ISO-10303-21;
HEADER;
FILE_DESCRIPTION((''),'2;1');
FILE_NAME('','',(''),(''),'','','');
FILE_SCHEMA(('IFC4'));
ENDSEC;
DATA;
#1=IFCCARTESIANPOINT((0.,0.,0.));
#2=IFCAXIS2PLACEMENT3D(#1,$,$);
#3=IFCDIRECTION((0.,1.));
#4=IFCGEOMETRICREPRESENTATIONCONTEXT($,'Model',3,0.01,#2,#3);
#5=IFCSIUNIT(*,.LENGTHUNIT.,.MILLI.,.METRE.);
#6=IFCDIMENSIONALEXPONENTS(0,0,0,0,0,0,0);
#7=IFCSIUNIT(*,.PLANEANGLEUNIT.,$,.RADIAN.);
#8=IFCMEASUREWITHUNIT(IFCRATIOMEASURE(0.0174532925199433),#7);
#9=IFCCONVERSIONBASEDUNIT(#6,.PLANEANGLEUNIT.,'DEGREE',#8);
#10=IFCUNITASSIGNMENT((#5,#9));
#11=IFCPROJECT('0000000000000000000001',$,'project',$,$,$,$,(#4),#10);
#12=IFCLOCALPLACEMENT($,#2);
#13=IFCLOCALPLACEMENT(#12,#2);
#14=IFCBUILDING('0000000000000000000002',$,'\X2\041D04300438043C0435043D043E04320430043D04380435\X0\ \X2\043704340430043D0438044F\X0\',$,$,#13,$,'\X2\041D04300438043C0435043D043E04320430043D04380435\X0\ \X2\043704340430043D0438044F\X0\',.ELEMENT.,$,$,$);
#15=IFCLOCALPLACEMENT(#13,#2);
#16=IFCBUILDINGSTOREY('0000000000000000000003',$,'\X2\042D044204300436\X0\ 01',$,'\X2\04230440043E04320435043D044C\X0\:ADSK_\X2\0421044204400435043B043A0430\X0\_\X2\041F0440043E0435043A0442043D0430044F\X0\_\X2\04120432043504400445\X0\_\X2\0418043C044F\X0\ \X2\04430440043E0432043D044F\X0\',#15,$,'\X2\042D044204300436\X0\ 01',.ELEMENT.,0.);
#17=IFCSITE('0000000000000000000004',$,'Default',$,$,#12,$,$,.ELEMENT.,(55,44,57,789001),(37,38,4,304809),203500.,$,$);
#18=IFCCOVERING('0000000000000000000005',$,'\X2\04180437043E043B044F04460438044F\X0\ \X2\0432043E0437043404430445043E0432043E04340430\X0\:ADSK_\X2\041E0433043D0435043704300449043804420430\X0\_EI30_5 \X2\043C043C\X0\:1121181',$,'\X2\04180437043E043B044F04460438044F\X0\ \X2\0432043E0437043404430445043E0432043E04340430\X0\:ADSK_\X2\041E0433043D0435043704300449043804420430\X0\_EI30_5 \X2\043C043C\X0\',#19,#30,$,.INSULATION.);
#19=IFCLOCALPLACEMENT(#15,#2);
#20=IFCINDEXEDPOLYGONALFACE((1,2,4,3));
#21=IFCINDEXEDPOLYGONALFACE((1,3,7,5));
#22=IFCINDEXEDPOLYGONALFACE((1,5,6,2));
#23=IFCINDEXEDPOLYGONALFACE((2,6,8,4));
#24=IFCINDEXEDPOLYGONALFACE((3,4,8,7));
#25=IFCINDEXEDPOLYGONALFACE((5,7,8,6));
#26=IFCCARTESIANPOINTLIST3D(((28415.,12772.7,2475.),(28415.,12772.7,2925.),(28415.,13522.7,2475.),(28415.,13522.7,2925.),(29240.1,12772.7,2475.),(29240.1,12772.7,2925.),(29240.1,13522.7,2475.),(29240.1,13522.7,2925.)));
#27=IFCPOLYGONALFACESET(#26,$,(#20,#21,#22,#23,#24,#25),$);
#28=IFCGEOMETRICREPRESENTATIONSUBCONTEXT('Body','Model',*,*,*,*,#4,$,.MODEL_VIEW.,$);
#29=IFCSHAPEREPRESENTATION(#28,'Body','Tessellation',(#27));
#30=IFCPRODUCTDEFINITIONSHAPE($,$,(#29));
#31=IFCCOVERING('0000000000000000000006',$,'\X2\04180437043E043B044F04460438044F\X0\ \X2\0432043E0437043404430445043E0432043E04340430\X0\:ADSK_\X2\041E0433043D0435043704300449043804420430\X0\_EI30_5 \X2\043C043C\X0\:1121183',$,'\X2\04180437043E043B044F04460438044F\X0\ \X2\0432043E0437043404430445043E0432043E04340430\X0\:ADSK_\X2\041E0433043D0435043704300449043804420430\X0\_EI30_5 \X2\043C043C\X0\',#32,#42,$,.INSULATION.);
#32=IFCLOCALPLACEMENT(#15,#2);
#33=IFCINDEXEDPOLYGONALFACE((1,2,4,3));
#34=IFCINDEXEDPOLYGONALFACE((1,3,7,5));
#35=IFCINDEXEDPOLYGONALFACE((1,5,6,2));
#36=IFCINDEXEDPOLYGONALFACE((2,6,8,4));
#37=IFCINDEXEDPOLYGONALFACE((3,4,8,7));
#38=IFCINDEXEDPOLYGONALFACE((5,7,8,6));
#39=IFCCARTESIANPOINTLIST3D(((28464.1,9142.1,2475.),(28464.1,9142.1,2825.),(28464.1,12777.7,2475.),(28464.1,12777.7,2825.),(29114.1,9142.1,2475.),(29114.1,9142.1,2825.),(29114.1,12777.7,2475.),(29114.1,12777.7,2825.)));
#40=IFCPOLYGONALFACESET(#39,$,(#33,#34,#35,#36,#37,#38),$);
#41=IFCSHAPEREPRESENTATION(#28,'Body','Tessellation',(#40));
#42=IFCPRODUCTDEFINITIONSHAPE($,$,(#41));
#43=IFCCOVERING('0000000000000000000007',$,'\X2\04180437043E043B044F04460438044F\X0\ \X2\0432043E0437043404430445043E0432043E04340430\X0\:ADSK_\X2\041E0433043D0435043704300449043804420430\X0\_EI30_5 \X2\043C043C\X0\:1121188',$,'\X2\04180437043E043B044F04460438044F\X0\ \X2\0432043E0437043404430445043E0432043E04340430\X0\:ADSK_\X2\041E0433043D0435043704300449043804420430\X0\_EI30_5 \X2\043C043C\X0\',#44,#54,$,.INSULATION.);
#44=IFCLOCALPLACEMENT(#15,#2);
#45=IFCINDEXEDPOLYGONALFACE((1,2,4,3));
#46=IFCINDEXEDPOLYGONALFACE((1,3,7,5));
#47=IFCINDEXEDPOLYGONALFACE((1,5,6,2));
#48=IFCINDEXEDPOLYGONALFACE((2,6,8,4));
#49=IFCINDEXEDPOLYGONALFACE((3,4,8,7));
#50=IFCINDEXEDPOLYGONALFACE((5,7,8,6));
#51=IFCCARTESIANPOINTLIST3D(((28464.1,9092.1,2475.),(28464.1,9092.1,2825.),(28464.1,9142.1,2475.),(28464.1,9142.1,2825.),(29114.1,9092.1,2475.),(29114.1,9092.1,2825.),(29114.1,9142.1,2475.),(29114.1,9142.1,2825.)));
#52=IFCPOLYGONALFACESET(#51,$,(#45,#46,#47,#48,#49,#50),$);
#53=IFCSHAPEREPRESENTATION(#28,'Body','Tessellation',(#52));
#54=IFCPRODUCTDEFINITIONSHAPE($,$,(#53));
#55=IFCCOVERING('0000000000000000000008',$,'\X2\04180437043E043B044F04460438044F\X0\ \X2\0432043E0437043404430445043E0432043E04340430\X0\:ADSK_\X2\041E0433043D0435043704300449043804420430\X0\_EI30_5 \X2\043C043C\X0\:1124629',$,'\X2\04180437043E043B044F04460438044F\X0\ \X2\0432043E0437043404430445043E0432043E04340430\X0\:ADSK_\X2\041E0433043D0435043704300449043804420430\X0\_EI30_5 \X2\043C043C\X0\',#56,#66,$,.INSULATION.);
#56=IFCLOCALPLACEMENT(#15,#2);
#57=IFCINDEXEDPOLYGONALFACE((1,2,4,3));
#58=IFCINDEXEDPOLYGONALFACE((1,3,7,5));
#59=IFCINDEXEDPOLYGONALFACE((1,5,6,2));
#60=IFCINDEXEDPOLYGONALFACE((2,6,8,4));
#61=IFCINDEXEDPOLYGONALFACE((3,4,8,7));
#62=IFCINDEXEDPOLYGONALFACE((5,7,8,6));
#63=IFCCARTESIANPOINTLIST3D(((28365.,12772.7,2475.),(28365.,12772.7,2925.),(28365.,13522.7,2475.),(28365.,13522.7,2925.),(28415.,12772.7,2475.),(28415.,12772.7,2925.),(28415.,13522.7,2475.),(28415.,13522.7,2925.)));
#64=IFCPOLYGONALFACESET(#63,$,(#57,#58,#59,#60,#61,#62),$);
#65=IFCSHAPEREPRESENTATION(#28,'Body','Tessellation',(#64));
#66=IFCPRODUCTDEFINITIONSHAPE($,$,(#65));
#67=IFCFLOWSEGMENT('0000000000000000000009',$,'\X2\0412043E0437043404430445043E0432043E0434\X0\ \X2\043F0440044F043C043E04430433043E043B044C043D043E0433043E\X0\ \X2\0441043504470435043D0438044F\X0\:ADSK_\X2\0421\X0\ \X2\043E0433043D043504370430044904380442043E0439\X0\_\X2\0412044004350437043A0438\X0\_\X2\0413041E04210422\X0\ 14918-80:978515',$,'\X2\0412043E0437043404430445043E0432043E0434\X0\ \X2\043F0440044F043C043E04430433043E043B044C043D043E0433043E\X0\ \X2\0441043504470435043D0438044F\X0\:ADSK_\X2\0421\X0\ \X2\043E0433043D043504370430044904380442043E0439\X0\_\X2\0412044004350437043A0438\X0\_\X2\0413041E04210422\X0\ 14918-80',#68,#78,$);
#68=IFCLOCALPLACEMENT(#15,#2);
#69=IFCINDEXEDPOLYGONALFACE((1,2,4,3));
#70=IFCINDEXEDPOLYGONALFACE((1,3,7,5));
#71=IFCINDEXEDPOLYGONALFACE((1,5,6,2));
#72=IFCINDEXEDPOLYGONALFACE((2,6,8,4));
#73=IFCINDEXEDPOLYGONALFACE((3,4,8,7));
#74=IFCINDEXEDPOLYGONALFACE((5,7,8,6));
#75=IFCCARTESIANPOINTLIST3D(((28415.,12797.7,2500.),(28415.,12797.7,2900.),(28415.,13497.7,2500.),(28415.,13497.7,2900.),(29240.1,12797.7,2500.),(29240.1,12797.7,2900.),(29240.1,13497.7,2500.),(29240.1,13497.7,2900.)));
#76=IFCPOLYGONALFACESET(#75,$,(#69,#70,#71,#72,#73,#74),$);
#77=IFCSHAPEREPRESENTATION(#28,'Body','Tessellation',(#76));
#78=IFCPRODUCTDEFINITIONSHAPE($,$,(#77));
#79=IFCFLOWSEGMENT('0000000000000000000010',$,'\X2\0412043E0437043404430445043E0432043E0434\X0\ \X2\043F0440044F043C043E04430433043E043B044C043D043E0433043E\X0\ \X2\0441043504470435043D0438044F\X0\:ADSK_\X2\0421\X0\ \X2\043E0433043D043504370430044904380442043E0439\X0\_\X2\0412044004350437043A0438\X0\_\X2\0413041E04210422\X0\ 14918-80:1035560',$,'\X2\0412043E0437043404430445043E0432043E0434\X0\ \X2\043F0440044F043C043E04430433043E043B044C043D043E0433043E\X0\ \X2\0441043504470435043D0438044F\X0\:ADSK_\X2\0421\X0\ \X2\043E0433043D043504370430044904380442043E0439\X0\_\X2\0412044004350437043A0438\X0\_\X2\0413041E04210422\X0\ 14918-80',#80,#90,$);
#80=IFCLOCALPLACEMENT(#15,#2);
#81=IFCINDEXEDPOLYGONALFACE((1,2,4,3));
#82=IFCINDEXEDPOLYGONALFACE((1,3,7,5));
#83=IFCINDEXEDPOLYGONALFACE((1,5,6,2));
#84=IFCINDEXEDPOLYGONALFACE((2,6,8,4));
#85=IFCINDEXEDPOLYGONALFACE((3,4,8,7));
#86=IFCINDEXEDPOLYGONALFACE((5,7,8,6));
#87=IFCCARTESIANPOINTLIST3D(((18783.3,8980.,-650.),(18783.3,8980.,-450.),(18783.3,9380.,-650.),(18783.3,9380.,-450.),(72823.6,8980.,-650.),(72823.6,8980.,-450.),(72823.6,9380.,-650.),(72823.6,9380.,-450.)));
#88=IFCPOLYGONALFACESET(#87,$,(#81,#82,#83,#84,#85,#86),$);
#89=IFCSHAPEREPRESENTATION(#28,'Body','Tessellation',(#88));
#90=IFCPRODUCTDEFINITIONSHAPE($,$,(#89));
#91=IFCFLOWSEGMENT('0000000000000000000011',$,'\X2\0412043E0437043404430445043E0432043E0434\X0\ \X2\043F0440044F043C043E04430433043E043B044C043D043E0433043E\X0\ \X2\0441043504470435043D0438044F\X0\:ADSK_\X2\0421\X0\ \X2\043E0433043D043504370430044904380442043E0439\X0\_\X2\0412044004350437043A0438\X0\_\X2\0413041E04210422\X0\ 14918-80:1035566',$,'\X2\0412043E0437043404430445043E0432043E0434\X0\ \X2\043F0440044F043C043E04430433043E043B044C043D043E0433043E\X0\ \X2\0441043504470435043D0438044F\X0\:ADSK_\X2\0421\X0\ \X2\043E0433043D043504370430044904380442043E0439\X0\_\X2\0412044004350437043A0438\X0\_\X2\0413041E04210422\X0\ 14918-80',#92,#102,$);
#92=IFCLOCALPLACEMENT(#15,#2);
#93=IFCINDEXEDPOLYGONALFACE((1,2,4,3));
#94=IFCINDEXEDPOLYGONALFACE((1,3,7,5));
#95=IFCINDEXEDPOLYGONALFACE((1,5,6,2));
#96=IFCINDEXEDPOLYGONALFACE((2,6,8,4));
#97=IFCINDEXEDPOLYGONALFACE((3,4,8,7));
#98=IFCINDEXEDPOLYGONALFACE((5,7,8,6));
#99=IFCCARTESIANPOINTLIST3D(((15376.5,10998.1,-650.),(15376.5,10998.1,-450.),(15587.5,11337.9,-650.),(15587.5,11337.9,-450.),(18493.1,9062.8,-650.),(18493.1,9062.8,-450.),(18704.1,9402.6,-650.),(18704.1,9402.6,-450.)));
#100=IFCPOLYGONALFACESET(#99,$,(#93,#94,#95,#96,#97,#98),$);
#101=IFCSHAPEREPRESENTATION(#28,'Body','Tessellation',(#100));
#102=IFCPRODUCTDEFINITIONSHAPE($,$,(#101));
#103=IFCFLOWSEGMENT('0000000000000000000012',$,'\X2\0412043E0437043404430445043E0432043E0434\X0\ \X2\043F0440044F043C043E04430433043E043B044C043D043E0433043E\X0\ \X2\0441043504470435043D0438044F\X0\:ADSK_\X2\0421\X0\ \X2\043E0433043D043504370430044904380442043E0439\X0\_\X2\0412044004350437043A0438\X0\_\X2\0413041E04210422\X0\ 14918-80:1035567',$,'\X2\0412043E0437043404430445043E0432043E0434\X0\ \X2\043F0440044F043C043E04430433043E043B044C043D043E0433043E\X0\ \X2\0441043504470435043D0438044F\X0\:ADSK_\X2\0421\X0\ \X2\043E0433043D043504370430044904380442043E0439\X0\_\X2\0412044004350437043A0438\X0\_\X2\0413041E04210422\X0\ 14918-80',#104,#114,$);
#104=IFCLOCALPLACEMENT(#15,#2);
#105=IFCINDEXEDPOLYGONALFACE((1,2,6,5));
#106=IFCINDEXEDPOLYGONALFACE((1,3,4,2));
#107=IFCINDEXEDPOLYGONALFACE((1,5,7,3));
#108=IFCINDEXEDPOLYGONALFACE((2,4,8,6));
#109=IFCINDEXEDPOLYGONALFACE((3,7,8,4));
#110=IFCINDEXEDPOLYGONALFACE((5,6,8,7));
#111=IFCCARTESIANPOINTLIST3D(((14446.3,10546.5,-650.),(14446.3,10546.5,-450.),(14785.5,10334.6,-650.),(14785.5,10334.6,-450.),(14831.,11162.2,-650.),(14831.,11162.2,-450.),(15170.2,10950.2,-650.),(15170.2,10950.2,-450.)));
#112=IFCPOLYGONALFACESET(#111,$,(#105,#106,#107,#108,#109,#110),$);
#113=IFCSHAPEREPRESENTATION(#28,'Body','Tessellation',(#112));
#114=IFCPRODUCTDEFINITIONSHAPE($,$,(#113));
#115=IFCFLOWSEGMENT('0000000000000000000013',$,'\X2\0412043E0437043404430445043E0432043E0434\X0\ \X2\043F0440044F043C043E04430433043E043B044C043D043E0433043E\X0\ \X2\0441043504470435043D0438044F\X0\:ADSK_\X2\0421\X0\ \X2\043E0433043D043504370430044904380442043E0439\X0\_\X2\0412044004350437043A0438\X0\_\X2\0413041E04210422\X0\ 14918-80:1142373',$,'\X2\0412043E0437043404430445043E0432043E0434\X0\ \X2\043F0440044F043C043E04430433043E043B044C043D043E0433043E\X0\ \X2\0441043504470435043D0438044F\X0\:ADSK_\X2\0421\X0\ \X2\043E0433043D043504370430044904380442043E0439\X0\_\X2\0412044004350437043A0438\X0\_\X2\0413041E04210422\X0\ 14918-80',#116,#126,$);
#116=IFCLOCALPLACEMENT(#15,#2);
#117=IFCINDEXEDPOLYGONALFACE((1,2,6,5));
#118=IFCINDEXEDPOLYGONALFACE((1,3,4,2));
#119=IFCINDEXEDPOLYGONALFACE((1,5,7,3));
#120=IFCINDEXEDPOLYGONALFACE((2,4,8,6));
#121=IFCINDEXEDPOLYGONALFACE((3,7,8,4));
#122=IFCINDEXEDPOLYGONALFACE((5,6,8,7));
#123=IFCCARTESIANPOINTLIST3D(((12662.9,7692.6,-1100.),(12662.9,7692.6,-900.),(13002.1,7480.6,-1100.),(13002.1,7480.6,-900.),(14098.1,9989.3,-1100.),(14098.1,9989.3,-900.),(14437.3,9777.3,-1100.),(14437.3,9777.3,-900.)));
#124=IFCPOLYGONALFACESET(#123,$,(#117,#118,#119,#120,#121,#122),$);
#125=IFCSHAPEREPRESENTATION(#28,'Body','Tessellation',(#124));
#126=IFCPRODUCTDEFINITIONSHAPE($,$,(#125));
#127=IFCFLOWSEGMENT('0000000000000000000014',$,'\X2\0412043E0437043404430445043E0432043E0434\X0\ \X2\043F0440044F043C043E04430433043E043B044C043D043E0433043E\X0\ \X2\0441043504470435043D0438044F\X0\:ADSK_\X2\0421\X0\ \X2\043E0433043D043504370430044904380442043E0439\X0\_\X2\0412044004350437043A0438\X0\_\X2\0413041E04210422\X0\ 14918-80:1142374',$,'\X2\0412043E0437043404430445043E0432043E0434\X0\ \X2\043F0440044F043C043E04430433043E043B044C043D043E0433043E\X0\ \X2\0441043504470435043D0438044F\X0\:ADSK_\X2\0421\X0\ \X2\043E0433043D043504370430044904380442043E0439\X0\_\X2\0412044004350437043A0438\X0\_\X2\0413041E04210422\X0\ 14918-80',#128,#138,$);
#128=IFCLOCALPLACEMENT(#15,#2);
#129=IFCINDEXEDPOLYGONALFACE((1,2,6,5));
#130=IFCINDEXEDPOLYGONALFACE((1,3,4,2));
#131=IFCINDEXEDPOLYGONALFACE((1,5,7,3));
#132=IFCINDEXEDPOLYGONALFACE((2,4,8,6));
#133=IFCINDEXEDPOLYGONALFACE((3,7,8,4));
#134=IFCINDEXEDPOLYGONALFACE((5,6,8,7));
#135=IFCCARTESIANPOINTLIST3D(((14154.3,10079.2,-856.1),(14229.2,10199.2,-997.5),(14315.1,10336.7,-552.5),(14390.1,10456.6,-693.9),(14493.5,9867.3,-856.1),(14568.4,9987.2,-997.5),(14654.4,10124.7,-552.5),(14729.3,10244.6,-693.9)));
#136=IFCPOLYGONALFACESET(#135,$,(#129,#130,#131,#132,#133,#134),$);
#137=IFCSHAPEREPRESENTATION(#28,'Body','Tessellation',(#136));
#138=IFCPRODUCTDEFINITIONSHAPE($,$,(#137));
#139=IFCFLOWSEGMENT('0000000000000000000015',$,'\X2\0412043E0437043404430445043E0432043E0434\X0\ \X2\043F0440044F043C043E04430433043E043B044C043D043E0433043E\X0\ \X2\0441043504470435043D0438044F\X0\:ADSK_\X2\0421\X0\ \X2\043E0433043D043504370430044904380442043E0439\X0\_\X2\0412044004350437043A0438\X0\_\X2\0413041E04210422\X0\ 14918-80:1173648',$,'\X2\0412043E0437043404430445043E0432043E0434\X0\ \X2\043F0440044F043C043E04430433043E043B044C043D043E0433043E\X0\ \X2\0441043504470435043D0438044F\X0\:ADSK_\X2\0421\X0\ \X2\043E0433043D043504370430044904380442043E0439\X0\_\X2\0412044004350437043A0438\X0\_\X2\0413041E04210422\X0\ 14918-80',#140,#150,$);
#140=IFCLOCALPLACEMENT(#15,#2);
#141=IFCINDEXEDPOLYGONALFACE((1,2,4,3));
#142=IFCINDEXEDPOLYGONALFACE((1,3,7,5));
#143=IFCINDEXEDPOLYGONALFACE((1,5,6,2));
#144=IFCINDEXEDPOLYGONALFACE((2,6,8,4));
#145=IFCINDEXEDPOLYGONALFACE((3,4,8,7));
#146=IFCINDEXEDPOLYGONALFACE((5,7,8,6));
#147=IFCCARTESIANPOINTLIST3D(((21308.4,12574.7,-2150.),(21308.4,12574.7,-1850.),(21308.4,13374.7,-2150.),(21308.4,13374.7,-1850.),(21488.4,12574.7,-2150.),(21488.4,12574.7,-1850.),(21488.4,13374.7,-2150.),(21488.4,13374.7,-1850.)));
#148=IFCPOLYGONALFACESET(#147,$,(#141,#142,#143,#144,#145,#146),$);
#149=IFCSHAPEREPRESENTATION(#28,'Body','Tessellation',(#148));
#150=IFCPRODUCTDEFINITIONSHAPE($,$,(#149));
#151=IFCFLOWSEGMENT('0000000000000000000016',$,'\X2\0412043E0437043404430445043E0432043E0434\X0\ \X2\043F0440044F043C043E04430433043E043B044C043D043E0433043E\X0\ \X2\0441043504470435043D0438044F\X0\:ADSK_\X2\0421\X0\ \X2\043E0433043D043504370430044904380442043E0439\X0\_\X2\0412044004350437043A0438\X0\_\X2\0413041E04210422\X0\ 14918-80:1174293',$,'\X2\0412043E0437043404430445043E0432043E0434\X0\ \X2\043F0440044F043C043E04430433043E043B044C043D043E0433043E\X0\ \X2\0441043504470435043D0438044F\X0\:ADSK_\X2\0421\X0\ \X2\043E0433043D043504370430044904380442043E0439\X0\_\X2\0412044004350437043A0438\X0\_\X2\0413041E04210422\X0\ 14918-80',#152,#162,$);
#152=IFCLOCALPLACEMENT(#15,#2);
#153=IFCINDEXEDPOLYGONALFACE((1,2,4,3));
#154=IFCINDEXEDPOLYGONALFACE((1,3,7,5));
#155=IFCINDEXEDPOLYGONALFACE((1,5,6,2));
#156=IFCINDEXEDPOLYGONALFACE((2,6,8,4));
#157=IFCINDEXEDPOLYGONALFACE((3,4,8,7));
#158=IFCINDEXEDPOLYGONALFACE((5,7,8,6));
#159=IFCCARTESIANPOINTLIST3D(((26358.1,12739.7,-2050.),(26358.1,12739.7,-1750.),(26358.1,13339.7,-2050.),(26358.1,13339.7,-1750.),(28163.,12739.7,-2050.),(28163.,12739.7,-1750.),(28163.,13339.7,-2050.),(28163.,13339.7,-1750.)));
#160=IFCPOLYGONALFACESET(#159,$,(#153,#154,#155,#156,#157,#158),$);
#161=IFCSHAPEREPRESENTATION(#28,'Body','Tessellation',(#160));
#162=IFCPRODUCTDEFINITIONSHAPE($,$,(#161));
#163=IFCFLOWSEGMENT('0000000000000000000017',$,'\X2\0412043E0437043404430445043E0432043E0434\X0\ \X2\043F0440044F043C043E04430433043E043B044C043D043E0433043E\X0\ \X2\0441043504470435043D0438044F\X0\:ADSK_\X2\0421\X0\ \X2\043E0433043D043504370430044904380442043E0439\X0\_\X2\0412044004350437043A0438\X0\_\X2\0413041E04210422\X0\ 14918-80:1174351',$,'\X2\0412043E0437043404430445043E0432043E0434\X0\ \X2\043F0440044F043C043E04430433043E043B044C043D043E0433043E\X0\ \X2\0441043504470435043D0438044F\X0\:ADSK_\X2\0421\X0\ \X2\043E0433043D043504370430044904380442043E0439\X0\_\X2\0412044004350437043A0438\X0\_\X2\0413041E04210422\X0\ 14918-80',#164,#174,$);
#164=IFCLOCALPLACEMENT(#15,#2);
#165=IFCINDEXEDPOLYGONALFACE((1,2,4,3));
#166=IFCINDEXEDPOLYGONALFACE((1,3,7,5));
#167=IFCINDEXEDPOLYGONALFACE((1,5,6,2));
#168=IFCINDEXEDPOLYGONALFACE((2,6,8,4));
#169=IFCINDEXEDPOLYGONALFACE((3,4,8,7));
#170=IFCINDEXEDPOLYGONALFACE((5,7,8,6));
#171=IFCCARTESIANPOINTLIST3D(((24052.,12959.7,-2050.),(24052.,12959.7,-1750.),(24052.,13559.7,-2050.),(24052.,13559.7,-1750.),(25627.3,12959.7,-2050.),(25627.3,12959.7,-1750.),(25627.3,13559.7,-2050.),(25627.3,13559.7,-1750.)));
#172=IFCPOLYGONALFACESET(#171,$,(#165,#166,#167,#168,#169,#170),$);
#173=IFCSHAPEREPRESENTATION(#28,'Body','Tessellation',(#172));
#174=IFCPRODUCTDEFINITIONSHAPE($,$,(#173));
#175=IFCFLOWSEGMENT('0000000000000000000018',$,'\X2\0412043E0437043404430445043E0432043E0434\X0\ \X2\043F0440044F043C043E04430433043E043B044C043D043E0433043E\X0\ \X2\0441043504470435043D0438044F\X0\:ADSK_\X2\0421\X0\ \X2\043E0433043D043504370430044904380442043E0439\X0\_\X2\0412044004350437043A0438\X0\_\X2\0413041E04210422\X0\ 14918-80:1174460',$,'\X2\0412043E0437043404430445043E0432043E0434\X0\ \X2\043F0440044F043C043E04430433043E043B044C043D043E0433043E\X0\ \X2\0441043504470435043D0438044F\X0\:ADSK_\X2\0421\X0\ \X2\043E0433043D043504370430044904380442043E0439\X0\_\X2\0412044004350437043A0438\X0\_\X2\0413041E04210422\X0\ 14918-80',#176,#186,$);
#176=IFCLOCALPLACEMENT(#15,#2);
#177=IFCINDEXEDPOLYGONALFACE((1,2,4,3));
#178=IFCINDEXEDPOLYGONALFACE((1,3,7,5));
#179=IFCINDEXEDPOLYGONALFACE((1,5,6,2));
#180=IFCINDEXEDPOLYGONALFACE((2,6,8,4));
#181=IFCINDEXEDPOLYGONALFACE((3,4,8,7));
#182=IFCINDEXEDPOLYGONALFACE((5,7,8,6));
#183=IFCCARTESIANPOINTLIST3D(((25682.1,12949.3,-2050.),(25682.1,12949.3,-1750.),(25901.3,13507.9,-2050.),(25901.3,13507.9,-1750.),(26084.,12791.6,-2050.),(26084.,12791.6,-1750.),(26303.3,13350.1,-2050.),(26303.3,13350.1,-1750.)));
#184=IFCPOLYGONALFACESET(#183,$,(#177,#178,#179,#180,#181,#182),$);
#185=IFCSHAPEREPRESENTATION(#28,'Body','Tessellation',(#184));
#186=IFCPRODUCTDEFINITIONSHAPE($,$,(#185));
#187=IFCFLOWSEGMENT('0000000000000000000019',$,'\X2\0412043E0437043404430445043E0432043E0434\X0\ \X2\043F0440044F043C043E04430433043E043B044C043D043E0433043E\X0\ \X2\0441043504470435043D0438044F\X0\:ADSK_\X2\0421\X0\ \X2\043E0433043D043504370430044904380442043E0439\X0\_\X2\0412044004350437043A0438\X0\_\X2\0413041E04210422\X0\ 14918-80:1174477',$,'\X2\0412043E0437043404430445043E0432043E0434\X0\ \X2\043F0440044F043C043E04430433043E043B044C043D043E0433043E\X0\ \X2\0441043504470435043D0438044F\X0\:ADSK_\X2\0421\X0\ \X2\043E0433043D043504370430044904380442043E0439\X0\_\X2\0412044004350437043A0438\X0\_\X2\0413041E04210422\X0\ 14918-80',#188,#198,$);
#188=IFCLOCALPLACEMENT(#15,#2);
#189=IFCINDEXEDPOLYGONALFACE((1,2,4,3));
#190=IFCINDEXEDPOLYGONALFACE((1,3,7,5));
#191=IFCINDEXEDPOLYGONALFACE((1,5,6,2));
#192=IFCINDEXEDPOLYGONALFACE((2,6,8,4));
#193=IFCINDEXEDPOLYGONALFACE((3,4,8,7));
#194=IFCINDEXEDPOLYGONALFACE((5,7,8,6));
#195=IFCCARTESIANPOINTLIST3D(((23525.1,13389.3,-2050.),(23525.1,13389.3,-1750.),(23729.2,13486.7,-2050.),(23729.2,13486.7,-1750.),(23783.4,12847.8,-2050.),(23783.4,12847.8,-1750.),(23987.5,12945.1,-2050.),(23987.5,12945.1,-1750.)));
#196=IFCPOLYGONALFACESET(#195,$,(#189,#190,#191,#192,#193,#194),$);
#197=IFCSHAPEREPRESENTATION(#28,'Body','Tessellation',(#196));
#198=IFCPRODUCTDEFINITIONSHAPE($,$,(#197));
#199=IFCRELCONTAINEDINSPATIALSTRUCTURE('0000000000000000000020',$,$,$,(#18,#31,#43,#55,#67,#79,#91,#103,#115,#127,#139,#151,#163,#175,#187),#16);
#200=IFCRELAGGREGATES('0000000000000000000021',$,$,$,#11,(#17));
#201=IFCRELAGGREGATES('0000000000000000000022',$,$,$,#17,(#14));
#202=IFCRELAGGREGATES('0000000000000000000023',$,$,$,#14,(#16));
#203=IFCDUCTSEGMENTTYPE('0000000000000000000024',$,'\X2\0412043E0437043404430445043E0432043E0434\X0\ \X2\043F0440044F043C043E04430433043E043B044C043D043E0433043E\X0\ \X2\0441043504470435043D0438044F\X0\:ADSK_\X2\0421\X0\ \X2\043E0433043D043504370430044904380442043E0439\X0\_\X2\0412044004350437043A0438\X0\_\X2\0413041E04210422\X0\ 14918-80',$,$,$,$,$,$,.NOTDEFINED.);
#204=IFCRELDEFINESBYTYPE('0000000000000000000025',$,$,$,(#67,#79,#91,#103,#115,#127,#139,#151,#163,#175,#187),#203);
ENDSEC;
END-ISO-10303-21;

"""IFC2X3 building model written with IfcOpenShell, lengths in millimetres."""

from ifc_helpers import new_model, entity, si_unit, converted_unit, direction, frame, frame_2d, origin, origin_2d_with_axis, place, context, subcontext, project, spatial, rectangle, extrude, type_object, element, save


model = new_model("IFC2X3")

# Units and contexts
model_context = context("Model", 3, precision=0.01, world=origin(), true_north=direction((0.0, 1.0)))
body_context = subcontext(model_context, "Body", "Model", "MODEL_VIEW")
ifc_project = project(units=[si_unit("LENGTHUNIT", "METRE", prefix="MILLI"), converted_unit("PLANEANGLEUNIT", "DEGREE", entity("IfcRatioMeasure", 0.0174532925199433), si_unit("PLANEANGLEUNIT", "RADIAN"), dimensions=[0, 0, 0, 0, 0, 0, 0])], contexts=[model_context])

# Site, building, storey
site_placement = place(None, frame((0.0, 0.0, 0.0)))
site = spatial("IfcSite", under=ifc_project, at=site_placement, Name="Default", CompositionType="ELEMENT", RefLatitude=(55, 44, 57, 789001), RefLongitude=(37, 38, 4, 304809), RefElevation=203500.0)
building_placement = place(site_placement, origin())
building = spatial("IfcBuilding", under=site, at=building_placement, Name="Наименование здания", LongName="Наименование здания", CompositionType="ELEMENT")
storey_placement = place(building_placement, origin())
storey = spatial("IfcBuildingStorey", under=building, at=storey_placement, Name="Этаж 01", ObjectType="Уровень:ADSK_Стрелка_Проектная_Вверх_Имя уровня", LongName="Этаж 01", CompositionType="ELEMENT", Elevation=0.0)

# Coverings
covering_1_placement = place(storey_placement, frame((28415.0, 12772.7, 2475.0)))
element("IfcCovering", 1, at=covering_1_placement, inside=storey, Name="Изоляция воздуховода:ADSK_Огнезащита_EI30_5 мм:1121181", ObjectType="Изоляция воздуховода:ADSK_Огнезащита_EI30_5 мм", PredefinedType="INSULATION", context=body_context, shape_type="SweptSolid", body=[
    extrude(rectangle(XDim=825.1, YDim=750.0, at=frame_2d((0.0, 0.0), x_axis=(1.0, 0.0))), frame((412.6, 375.0, 0.0), z_axis=(0.0, 0.0, 1.0), x_axis=(-1.0, 0.0, 0.0)), (0.0, 0.0, 1.0), 450.0),
])
covering_2_placement = place(storey_placement, frame((28464.1, 9142.1, 2475.0)))
element("IfcCovering", 2, at=covering_2_placement, inside=storey, Name="Изоляция воздуховода:ADSK_Огнезащита_EI30_5 мм:1121183", ObjectType="Изоляция воздуховода:ADSK_Огнезащита_EI30_5 мм", PredefinedType="INSULATION", context=body_context, shape_type="SweptSolid", body=[
    extrude(rectangle(XDim=3635.6, YDim=650.0, at=frame_2d((0.0, 0.0), x_axis=(1.0, 0.0))), frame((325.0, 1817.8, 0.0), z_axis=(0.0, 0.0, 1.0), x_axis=(0.0, -1.0, 0.0)), (0.0, 0.0, 1.0), 350.0),
])
covering_3_placement = place(storey_placement, frame((28464.1, 9092.1, 2475.0)))
element("IfcCovering", 3, at=covering_3_placement, inside=storey, Name="Изоляция воздуховода:ADSK_Огнезащита_EI30_5 мм:1121188", ObjectType="Изоляция воздуховода:ADSK_Огнезащита_EI30_5 мм", PredefinedType="INSULATION", context=body_context, shape_type="SweptSolid", body=[
    extrude(rectangle(XDim=50.0, YDim=650.0, at=origin_2d_with_axis()), frame((325.0, 25.0, 0.0), z_axis=(0.0, 0.0, 1.0), x_axis=(0.0, 1.0, 0.0)), (0.0, 0.0, 1.0), 350.0),
])
covering_4_placement = place(storey_placement, frame((28365.0, 12772.7, 2475.0)))
element("IfcCovering", 4, at=covering_4_placement, inside=storey, Name="Изоляция воздуховода:ADSK_Огнезащита_EI30_5 мм:1124629", ObjectType="Изоляция воздуховода:ADSK_Огнезащита_EI30_5 мм", PredefinedType="INSULATION", context=body_context, shape_type="SweptSolid", body=[
    extrude(rectangle(XDim=50.0, YDim=750.0, at=frame_2d((0.0, 0.0), x_axis=(1.0, 0.0))), frame((25.0, 375.0, 0.0)), (0.0, 0.0, 1.0), 450.0),
])

# Flow segments
duct_segment_type = type_object("IfcDuctSegmentType", Name="Воздуховод прямоугольного сечения:ADSK_С огнезащитой_Врезки_ГОСТ 14918-80", PredefinedType="NOTDEFINED")
flow_segment_1_placement = place(storey_placement, frame((28415.0, 12797.7, 2500.0)))
element("IfcFlowSegment", 5, at=flow_segment_1_placement, inside=storey, type_object=duct_segment_type, Name="Воздуховод прямоугольного сечения:ADSK_С огнезащитой_Врезки_ГОСТ 14918-80:978515", ObjectType="Воздуховод прямоугольного сечения:ADSK_С огнезащитой_Врезки_ГОСТ 14918-80", context=body_context, shape_type="SweptSolid", body=[
    extrude(rectangle(XDim=825.1, YDim=700.0, at=frame_2d((0.0, 0.0), x_axis=(1.0, 0.0))), frame((412.6, 350.0, 0.0), z_axis=(0.0, 0.0, 1.0), x_axis=(-1.0, 0.0, 0.0)), (0.0, 0.0, 1.0), 400.0),
])
flow_segment_2_placement = place(storey_placement, frame((18783.3, 8980.0, -650.0)))
element("IfcFlowSegment", 6, at=flow_segment_2_placement, inside=storey, type_object=duct_segment_type, Name="Воздуховод прямоугольного сечения:ADSK_С огнезащитой_Врезки_ГОСТ 14918-80:1035560", ObjectType="Воздуховод прямоугольного сечения:ADSK_С огнезащитой_Врезки_ГОСТ 14918-80", context=body_context, shape_type="SweptSolid", body=[
    extrude(rectangle(XDim=54040.3, YDim=400.0, at=frame_2d((0.0, 0.0), x_axis=(1.0, 0.0))), frame((27020.1, 200.0, 0.0), z_axis=(0.0, 0.0, 1.0), x_axis=(-1.0, 0.0, 0.0)), (0.0, 0.0, 1.0), 200.0),
])
flow_segment_3_placement = place(storey_placement, frame((15376.5, 9062.8, -650.0)))
element("IfcFlowSegment", 7, at=flow_segment_3_placement, inside=storey, type_object=duct_segment_type, Name="Воздуховод прямоугольного сечения:ADSK_С огнезащитой_Врезки_ГОСТ 14918-80:1035566", ObjectType="Воздуховод прямоугольного сечения:ADSK_С огнезащитой_Врезки_ГОСТ 14918-80", context=body_context, shape_type="SweptSolid", body=[
    extrude(rectangle(XDim=3668.6, YDim=400.0, at=frame_2d((0.0, 0.0), x_axis=(1.0, 0.0))), frame((1663.8, 1137.6, 0.0), z_axis=(0.0, 0.0, 1.0), x_axis=(-0.849526, 0.527546, 0.0)), (0.0, 0.0, 1.0), 200.0),
])
flow_segment_4_placement = place(storey_placement, frame((14446.3, 10334.6, -650.0)))
element("IfcFlowSegment", 8, at=flow_segment_4_placement, inside=storey, type_object=duct_segment_type, Name="Воздуховод прямоугольного сечения:ADSK_С огнезащитой_Врезки_ГОСТ 14918-80:1035567", ObjectType="Воздуховод прямоугольного сечения:ADSK_С огнезащитой_Врезки_ГОСТ 14918-80", context=body_context, shape_type="SweptSolid", body=[
    extrude(rectangle(XDim=725.9, YDim=400.0, at=frame_2d((0.0, 0.0), x_axis=(1.0, 0.0))), frame((362.0, 413.8, 0.0), z_axis=(0.0, 0.0, 1.0), x_axis=(-0.529919, -0.848048, 0.0)), (0.0, 0.0, 1.0), 200.0),
])
flow_segment_5_placement = place(storey_placement, frame((12662.9, 7480.6, -1100.0)))
element("IfcFlowSegment", 9, at=flow_segment_5_placement, inside=storey, type_object=duct_segment_type, Name="Воздуховод прямоугольного сечения:ADSK_С огнезащитой_Врезки_ГОСТ 14918-80:1142373", ObjectType="Воздуховод прямоугольного сечения:ADSK_С огнезащитой_Врезки_ГОСТ 14918-80", context=body_context, shape_type="SweptSolid", body=[
    extrude(rectangle(XDim=2708.2, YDim=400.0, at=frame_2d((0.0, 0.0), x_axis=(1.0, 0.0))), frame((887.2, 1254.3, 0.0), z_axis=(0.0, 0.0, 1.0), x_axis=(0.529919, 0.848048, 0.0)), (0.0, 0.0, 1.0), 200.0),
])
flow_segment_6_placement = place(storey_placement, frame((14154.3, 9867.3, -997.5)))
element("IfcFlowSegment", 10, at=flow_segment_6_placement, inside=storey, type_object=duct_segment_type, Name="Воздуховод прямоугольного сечения:ADSK_С огнезащитой_Врезки_ГОСТ 14918-80:1142374", ObjectType="Воздуховод прямоугольного сечения:ADSK_С огнезащитой_Врезки_ГОСТ 14918-80", context=body_context, shape_type="SweptSolid", body=[
    extrude(rectangle(XDim=200.0, YDim=400.0, at=frame_2d((0.0, 0.0), x_axis=(1.0, 0.0))), frame((207.1, 165.9, 70.7), z_axis=(0.37471, 0.599661, 0.707107), x_axis=(-0.37471, -0.599661, 0.707107)), (0.0, 0.0, 1.0), 429.3),
])
flow_segment_7_placement = place(storey_placement, frame((21308.4, 12574.7, -2150.0)))
element("IfcFlowSegment", 11, at=flow_segment_7_placement, inside=storey, type_object=duct_segment_type, Name="Воздуховод прямоугольного сечения:ADSK_С огнезащитой_Врезки_ГОСТ 14918-80:1173648", ObjectType="Воздуховод прямоугольного сечения:ADSK_С огнезащитой_Врезки_ГОСТ 14918-80", context=body_context, shape_type="SweptSolid", body=[
    extrude(rectangle(XDim=180.0, YDim=800.0, at=origin_2d_with_axis()), frame((90.0, 400.0, 0.0)), (0.0, 0.0, 1.0), 300.0),
])
flow_segment_8_placement = place(storey_placement, frame((26358.1, 12739.7, -2050.0)))
element("IfcFlowSegment", 12, at=flow_segment_8_placement, inside=storey, type_object=duct_segment_type, Name="Воздуховод прямоугольного сечения:ADSK_С огнезащитой_Врезки_ГОСТ 14918-80:1174293", ObjectType="Воздуховод прямоугольного сечения:ADSK_С огнезащитой_Врезки_ГОСТ 14918-80", context=body_context, shape_type="SweptSolid", body=[
    extrude(rectangle(XDim=1804.9, YDim=600.0, at=frame_2d((0.0, 0.0), x_axis=(1.0, 0.0))), frame((902.5, 300.0, 0.0)), (0.0, 0.0, 1.0), 300.0),
])
flow_segment_9_placement = place(storey_placement, frame((24052.0, 12959.7, -2050.0)))
element("IfcFlowSegment", 13, at=flow_segment_9_placement, inside=storey, type_object=duct_segment_type, Name="Воздуховод прямоугольного сечения:ADSK_С огнезащитой_Врезки_ГОСТ 14918-80:1174351", ObjectType="Воздуховод прямоугольного сечения:ADSK_С огнезащитой_Врезки_ГОСТ 14918-80", context=body_context, shape_type="SweptSolid", body=[
    extrude(rectangle(XDim=1575.3, YDim=600.0, at=frame_2d((0.0, 0.0), x_axis=(1.0, 0.0))), frame((787.6, 300.0, 0.0), z_axis=(0.0, 0.0, 1.0), x_axis=(-1.0, 0.0, 0.0)), (0.0, 0.0, 1.0), 300.0),
])
flow_segment_10_placement = place(storey_placement, frame((25682.1, 12791.6, -2050.0)))
element("IfcFlowSegment", 14, at=flow_segment_10_placement, inside=storey, type_object=duct_segment_type, Name="Воздуховод прямоугольного сечения:ADSK_С огнезащитой_Врезки_ГОСТ 14918-80:1174460", ObjectType="Воздуховод прямоугольного сечения:ADSK_С огнезащитой_Врезки_ГОСТ 14918-80", context=body_context, shape_type="SweptSolid", body=[
    extrude(rectangle(XDim=431.8, YDim=600.0, at=frame_2d((0.0, 0.0), x_axis=(1.0, 0.0))), frame((310.6, 358.1, 0.0), z_axis=(0.0, 0.0, 1.0), x_axis=(-0.930852, 0.365397, 0.0)), (0.0, 0.0, 1.0), 300.0),
])
flow_segment_11_placement = place(storey_placement, frame((23525.1, 12847.8, -2050.0)))
element("IfcFlowSegment", 15, at=flow_segment_11_placement, inside=storey, type_object=duct_segment_type, Name="Воздуховод прямоугольного сечения:ADSK_С огнезащитой_Врезки_ГОСТ 14918-80:1174477", ObjectType="Воздуховод прямоугольного сечения:ADSK_С огнезащитой_Врезки_ГОСТ 14918-80", context=body_context, shape_type="SweptSolid", body=[
    extrude(rectangle(XDim=226.1, YDim=600.0, at=origin_2d_with_axis()), frame((231.2, 319.4, 0.0), z_axis=(0.0, 0.0, 1.0), x_axis=(0.902595, 0.430491, 0.0)), (0.0, 0.0, 1.0), 300.0),
])

save(model, "model.ifc")
